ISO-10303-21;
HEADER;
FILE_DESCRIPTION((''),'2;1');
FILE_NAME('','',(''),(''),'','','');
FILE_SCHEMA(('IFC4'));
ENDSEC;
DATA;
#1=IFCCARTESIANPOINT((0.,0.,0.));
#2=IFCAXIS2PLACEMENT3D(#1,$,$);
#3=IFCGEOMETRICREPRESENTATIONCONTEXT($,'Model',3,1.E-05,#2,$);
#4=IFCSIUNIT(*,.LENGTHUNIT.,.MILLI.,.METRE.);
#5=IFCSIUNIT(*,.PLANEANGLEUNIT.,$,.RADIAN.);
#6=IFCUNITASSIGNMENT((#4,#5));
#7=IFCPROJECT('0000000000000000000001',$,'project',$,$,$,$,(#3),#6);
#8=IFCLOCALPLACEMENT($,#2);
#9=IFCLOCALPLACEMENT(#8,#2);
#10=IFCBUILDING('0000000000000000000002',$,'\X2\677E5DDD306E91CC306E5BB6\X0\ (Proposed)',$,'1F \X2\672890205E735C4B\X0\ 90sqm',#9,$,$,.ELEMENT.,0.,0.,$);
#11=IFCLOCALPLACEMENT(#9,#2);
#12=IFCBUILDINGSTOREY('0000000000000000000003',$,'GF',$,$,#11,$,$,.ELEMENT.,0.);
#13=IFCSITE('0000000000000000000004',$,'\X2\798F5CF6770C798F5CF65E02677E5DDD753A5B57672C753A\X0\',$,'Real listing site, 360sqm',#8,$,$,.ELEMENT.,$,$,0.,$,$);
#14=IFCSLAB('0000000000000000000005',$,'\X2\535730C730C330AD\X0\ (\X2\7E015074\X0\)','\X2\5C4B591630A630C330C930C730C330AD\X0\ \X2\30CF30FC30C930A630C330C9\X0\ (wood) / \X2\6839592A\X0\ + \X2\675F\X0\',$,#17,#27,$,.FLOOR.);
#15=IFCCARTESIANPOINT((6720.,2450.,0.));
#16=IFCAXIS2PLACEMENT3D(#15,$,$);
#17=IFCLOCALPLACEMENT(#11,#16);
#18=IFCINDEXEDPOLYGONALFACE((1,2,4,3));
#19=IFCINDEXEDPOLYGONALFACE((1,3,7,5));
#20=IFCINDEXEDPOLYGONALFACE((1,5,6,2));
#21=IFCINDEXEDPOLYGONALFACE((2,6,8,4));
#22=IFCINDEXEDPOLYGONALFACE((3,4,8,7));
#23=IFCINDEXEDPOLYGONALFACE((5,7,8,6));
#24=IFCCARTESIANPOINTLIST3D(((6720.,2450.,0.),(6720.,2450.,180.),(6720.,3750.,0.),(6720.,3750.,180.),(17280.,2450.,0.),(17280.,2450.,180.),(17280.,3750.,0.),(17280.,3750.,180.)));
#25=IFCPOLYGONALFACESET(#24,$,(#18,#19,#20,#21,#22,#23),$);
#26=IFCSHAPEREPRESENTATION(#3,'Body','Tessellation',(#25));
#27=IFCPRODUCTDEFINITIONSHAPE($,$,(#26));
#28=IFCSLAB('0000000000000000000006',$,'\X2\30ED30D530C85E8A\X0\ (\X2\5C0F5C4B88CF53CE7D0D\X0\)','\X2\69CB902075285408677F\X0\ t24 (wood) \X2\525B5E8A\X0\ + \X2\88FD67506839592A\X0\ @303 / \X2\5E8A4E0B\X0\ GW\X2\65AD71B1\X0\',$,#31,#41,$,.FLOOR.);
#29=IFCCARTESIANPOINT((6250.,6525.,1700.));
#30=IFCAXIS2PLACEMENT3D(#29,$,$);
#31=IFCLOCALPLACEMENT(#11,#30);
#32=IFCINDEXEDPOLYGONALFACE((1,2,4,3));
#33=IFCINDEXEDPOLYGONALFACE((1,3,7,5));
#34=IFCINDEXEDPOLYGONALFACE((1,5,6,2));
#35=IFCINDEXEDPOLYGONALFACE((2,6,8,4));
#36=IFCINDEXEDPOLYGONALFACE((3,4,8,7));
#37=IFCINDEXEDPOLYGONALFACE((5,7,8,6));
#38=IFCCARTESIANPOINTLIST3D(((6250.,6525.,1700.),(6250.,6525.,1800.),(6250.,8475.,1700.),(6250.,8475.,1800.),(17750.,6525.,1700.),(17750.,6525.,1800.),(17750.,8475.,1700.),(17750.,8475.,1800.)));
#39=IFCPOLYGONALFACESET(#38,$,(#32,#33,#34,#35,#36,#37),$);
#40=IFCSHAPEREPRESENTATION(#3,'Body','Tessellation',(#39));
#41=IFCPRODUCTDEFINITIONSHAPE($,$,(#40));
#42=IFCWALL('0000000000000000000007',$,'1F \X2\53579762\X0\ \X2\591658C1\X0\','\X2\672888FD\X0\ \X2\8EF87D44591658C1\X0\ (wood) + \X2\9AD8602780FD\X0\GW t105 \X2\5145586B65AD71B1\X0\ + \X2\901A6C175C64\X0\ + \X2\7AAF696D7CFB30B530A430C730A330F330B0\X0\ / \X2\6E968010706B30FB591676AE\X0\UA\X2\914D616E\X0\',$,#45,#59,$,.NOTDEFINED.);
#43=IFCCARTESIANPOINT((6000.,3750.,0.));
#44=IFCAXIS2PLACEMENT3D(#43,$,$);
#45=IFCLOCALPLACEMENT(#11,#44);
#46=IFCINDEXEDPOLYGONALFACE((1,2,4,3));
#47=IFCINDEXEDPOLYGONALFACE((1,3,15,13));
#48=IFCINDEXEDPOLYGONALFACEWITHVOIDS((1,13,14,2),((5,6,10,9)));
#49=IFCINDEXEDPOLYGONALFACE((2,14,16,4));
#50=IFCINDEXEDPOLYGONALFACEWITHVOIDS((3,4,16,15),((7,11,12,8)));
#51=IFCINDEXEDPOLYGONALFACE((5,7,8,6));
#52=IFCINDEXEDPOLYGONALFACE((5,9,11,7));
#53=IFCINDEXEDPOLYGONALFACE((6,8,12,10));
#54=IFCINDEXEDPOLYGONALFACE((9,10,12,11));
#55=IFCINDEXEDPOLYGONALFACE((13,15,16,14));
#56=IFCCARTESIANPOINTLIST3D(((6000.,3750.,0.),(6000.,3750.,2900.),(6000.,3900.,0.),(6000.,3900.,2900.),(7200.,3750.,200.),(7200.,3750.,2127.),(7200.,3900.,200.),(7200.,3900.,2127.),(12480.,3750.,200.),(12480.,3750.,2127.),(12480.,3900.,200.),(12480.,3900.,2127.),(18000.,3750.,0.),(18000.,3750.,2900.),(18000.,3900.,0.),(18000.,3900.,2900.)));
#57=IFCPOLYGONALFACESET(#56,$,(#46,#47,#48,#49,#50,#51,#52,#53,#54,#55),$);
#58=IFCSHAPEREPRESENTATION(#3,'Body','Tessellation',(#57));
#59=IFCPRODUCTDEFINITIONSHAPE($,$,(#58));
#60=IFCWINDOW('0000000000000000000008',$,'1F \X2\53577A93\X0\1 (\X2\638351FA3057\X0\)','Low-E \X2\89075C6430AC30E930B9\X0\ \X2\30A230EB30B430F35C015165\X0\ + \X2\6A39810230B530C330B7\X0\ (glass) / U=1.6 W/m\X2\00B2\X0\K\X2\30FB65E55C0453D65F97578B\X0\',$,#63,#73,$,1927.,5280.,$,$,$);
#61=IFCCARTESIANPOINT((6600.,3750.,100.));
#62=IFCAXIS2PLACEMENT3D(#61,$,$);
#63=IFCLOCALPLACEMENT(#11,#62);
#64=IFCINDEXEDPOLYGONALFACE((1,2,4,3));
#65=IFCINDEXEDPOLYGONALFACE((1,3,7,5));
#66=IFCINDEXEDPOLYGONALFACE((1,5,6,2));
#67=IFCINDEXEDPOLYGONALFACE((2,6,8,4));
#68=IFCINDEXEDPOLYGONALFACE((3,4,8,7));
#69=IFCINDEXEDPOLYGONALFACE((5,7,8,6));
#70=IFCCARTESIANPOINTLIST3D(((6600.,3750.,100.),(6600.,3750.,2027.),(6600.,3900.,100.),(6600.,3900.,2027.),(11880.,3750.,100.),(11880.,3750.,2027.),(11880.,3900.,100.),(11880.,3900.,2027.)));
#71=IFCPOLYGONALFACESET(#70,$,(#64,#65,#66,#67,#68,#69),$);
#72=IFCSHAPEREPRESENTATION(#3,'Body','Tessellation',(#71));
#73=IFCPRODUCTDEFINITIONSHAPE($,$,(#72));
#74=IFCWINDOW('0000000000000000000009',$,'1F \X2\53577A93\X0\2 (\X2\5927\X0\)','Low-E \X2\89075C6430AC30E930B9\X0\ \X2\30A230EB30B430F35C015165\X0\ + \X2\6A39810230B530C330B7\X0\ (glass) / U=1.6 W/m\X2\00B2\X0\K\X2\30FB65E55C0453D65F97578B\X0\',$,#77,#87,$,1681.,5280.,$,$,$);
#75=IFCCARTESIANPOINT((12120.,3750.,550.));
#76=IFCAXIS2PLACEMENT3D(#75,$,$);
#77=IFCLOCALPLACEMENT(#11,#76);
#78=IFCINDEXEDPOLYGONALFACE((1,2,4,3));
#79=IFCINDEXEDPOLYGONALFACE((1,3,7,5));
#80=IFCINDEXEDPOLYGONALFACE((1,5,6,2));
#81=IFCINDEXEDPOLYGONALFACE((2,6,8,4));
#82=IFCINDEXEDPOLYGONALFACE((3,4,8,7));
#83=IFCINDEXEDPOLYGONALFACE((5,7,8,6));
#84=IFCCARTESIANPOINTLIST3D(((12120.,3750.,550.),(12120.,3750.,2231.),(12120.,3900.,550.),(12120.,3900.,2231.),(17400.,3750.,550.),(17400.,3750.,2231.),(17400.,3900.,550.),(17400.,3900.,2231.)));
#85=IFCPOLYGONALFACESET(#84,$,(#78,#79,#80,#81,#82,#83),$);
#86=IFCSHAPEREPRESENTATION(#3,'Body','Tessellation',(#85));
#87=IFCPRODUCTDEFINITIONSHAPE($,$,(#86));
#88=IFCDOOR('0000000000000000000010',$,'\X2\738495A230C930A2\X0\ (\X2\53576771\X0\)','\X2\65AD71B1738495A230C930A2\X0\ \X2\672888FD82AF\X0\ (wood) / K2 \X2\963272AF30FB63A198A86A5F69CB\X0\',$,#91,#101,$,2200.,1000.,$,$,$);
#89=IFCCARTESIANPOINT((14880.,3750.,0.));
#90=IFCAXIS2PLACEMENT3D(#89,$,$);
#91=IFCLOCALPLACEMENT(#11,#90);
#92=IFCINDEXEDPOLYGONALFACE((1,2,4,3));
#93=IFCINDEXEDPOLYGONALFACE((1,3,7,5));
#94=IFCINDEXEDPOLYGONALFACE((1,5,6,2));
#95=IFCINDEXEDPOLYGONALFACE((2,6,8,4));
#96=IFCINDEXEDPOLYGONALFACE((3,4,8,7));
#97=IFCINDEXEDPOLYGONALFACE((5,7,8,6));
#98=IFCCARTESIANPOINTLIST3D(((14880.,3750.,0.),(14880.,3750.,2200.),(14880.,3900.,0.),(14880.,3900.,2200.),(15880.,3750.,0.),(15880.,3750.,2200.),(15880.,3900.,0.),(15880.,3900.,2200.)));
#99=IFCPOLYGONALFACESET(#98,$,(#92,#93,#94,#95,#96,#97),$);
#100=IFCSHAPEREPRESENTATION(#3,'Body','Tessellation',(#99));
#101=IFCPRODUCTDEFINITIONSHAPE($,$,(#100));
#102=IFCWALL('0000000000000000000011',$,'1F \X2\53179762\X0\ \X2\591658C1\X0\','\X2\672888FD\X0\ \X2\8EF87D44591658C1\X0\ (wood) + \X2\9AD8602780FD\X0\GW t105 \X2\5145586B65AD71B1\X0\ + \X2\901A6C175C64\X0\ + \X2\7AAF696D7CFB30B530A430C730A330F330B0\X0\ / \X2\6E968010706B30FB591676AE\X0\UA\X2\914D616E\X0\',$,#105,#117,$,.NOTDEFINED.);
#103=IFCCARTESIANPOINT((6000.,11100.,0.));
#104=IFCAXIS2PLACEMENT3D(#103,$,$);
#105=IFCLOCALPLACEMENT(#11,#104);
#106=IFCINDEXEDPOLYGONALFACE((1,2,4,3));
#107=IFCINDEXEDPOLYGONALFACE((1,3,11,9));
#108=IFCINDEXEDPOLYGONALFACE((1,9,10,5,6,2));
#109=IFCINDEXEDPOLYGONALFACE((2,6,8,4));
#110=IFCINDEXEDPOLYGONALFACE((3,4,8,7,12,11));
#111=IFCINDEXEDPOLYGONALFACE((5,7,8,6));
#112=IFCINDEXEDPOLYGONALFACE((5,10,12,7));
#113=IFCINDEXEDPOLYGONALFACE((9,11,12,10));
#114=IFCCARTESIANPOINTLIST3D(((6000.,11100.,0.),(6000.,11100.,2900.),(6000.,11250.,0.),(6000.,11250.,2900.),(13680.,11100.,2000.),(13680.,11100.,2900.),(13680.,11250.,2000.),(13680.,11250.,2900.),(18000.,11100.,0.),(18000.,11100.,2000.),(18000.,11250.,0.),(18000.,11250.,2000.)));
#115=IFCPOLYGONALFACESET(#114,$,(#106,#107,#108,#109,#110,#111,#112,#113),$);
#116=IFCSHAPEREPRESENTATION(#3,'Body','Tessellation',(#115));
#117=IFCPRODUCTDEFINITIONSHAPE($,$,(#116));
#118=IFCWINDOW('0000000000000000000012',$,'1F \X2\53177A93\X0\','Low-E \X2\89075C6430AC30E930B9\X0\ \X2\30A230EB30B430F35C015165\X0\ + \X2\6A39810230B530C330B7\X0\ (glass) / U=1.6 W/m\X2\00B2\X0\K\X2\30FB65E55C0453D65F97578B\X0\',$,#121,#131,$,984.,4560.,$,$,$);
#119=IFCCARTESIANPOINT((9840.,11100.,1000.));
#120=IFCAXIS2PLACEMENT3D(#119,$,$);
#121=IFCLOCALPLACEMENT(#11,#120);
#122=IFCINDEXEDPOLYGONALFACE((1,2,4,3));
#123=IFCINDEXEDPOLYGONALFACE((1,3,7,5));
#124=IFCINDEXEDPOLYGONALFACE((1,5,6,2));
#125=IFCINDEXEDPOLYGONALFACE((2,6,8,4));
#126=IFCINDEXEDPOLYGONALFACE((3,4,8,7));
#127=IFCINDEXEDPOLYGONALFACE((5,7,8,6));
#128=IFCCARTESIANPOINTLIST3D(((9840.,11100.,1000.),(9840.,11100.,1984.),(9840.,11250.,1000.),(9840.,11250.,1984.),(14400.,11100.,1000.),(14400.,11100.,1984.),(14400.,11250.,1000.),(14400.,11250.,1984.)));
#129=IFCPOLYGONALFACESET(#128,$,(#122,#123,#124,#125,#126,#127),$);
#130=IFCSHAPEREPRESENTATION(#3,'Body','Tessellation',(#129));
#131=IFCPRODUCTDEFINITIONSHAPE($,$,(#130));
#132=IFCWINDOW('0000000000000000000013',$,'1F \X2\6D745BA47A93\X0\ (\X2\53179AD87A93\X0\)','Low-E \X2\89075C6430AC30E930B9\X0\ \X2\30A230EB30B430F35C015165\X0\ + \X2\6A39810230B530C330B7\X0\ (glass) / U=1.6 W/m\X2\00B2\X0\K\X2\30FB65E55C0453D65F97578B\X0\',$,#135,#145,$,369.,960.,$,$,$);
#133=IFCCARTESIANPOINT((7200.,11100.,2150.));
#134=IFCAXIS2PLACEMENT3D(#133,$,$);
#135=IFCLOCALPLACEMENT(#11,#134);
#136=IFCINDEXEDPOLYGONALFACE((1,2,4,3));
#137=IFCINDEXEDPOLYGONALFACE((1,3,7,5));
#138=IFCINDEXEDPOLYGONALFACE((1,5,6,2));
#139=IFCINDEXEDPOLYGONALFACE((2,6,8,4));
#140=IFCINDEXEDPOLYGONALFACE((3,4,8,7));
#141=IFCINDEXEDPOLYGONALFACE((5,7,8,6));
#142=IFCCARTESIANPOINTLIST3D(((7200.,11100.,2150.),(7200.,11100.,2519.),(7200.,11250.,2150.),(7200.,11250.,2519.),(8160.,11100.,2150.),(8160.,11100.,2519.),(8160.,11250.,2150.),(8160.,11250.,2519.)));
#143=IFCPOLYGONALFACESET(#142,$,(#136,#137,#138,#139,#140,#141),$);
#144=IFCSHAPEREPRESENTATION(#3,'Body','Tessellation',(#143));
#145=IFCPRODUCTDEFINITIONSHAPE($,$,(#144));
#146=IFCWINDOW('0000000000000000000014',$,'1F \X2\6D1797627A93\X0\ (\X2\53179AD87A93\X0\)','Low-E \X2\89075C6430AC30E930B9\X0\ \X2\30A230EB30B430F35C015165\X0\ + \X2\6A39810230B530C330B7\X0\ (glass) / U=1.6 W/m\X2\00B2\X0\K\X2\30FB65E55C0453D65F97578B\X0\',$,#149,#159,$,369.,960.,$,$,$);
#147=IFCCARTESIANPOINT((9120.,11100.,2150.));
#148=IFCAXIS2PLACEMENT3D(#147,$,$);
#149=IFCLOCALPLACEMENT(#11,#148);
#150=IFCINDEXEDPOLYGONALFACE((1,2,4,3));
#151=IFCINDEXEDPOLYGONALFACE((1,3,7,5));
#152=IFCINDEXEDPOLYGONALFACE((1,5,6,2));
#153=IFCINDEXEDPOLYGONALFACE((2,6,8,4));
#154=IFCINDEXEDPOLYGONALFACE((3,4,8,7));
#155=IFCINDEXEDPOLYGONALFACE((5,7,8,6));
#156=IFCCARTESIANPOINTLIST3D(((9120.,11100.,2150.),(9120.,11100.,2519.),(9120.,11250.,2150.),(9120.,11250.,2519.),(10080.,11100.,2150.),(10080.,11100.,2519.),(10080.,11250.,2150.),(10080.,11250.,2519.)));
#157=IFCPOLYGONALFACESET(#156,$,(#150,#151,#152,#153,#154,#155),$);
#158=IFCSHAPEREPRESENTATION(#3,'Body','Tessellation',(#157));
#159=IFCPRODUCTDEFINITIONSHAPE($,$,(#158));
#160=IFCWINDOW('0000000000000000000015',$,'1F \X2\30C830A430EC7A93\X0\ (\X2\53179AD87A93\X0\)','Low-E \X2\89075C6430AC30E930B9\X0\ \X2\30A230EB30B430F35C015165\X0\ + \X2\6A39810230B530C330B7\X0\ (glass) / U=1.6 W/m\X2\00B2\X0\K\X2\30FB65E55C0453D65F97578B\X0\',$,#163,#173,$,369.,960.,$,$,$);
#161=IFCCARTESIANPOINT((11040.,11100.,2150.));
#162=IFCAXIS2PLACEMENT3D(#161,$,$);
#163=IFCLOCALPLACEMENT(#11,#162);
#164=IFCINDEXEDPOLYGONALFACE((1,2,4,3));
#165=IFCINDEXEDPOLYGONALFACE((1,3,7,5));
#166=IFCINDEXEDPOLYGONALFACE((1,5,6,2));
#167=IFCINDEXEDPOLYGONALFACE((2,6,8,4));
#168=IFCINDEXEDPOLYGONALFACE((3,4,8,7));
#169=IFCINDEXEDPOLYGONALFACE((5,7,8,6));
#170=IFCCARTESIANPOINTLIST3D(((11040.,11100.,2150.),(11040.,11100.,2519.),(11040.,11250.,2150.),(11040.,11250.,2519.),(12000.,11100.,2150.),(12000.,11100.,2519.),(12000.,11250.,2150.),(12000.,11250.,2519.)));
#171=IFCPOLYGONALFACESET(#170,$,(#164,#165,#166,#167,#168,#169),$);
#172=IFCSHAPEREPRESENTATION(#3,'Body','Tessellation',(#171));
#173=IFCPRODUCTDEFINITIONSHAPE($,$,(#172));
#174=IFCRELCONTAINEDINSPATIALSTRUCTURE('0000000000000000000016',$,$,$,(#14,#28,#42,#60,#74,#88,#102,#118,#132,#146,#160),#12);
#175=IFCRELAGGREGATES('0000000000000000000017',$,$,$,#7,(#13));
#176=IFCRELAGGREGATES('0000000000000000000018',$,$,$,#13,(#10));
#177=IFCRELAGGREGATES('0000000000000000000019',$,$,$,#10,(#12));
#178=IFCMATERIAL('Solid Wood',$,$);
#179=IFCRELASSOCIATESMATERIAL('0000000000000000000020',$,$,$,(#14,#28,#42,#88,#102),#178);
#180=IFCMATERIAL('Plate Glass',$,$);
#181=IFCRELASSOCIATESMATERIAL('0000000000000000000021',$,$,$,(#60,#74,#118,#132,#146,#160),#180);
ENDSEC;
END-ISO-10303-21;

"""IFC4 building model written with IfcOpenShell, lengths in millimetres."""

from ifc_helpers import new_model, si_unit, frame, frame_2d, origin, place, context, project, spatial, rectangle, extrude, material, element, fill, save


model = new_model("IFC4")

# Units and contexts
model_context = context("Model", 3, precision=1e-05, world=origin())
ifc_project = project(units=[si_unit("LENGTHUNIT", "METRE", prefix="MILLI"), si_unit("PLANEANGLEUNIT", "RADIAN")], contexts=[model_context])

# Site, building, storey
site_placement = place(None, origin())
site = spatial("IfcSite", under=ifc_project, at=site_placement, Name="福島県福島市松川町字本町", ObjectType="Real listing site, 360sqm", CompositionType="ELEMENT", RefElevation=0.0)
building_placement = place(site_placement, origin())
building = spatial("IfcBuilding", under=site, at=building_placement, Name="松川の里の家 (Proposed)", ObjectType="1F 木造平屋 90sqm", CompositionType="ELEMENT", ElevationOfRefHeight=0.0, ElevationOfTerrain=0.0)
storey_placement = place(building_placement, origin())
storey = spatial("IfcBuildingStorey", under=building, at=storey_placement, Name="GF", CompositionType="ELEMENT", Elevation=0.0)

# Slabs
ifc_material_1 = material(Name="Solid Wood")
slab_1_placement = place(storey_placement, frame((6720.0, 2450.0, 0.0)))
element("IfcSlab", 1, at=slab_1_placement, inside=storey, material=ifc_material_1, Name="南デッキ (縁側)", Description="屋外ウッドデッキ ハードウッド (wood) / 根太 + 束", PredefinedType="FLOOR", context=model_context, shape_type="SweptSolid", body=[
    extrude(rectangle(XDim=10560.0, YDim=1300.0, at=frame_2d((5280.0, 650.0))), frame((6720.0, 2450.0, 0.0)), (0.0, 0.0, 1.0), 180.0),
])
slab_2_placement = place(storey_placement, frame((6250.0, 6525.0, 1700.0)))
element("IfcSlab", 2, at=slab_2_placement, inside=storey, material=ifc_material_1, Name="ロフト床 (小屋裏収納)", Description="構造用合板 t24 (wood) 剛床 + 製材根太 @303 / 床下 GW断熱", PredefinedType="FLOOR", context=model_context, shape_type="SweptSolid", body=[
    extrude(rectangle(XDim=11500.0, YDim=1950.0, at=frame_2d((5750.0, 975.0))), frame((6250.0, 6525.0, 1700.0)), (0.0, 0.0, 1.0), 100.0),
])

# Wall, openings, windows, door
wall_1_placement = place(storey_placement, frame((6000.0, 3750.0, 0.0)))
wall_1 = element("IfcWall", 3, at=wall_1_placement, inside=storey, material=ifc_material_1, Name="1F 南面 外壁", Description="木製 軸組外壁 (wood) + 高性能GW t105 充填断熱 + 通気層 + 窯業系サイディング / 準耐火・外皮UA配慮", PredefinedType="NOTDEFINED", context=model_context, shape_type="SweptSolid", body=[
    extrude(rectangle(XDim=12000.0, YDim=150.0, at=frame_2d((6000.0, 75.0))), frame((6000.0, 3750.0, 0.0)), (0.0, 0.0, 1.0), 2900.0),
])
opening_1_placement = place(storey_placement, frame((6600.0, 3750.0, 100.0)))
opening_1 = element("IfcOpeningElement", 4, at=opening_1_placement, cuts=wall_1, PredefinedType="NOTDEFINED", context=model_context, shape_type="SweptSolid", body=[
    extrude(rectangle(XDim=5280.0, YDim=150.0, at=frame_2d((2640.0, 75.0))), frame((6600.0, 3750.0, 100.0)), (0.0, 0.0, 1.0), 1927.0),
])
opening_2_placement = place(storey_placement, frame((12120.0, 3750.0, 550.0)))
opening_2 = element("IfcOpeningElement", 5, at=opening_2_placement, cuts=wall_1, PredefinedType="NOTDEFINED", context=model_context, shape_type="SweptSolid", body=[
    extrude(rectangle(XDim=5280.0, YDim=150.0, at=frame_2d((2640.0, 75.0))), frame((12120.0, 3750.0, 550.0)), (0.0, 0.0, 1.0), 1681.0),
])
opening_3_placement = place(storey_placement, frame((14880.0, 3750.0, 0.0)))
opening_3 = element("IfcOpeningElement", 6, at=opening_3_placement, cuts=wall_1, PredefinedType="NOTDEFINED", context=model_context, shape_type="SweptSolid", body=[
    extrude(rectangle(XDim=1000.0, YDim=150.0, at=frame_2d((500.0, 75.0))), frame((14880.0, 3750.0, 0.0)), (0.0, 0.0, 1.0), 2200.0),
])
ifc_material_2 = material(Name="Plate Glass")
window_1_placement = place(storey_placement, frame((6600.0, 3750.0, 100.0)))
window_1 = element("IfcWindow", 7, at=window_1_placement, inside=storey, material=ifc_material_2, Name="1F 南窓1 (掃出し)", Description="Low-E 複層ガラス アルゴン封入 + 樹脂サッシ (glass) / U=1.6 W/m²K・日射取得型", OverallHeight=1927.0, OverallWidth=5280.0, context=model_context, shape_type="SweptSolid", body=[
    extrude(rectangle(XDim=5280.0, YDim=150.0, at=frame_2d((2640.0, 75.0))), frame((6600.0, 3750.0, 100.0)), (0.0, 0.0, 1.0), 1927.0),
])
fill(opening_1, window_1)
window_2_placement = place(storey_placement, frame((12120.0, 3750.0, 550.0)))
window_2 = element("IfcWindow", 8, at=window_2_placement, inside=storey, material=ifc_material_2, Name="1F 南窓2 (大)", Description="Low-E 複層ガラス アルゴン封入 + 樹脂サッシ (glass) / U=1.6 W/m²K・日射取得型", OverallHeight=1681.0, OverallWidth=5280.0, context=model_context, shape_type="SweptSolid", body=[
    extrude(rectangle(XDim=5280.0, YDim=150.0, at=frame_2d((2640.0, 75.0))), frame((12120.0, 3750.0, 550.0)), (0.0, 0.0, 1.0), 1681.0),
])
fill(opening_2, window_2)
door_1_placement = place(storey_placement, frame((14880.0, 3750.0, 0.0)))
door_1 = element("IfcDoor", 9, at=door_1_placement, inside=storey, material=ifc_material_1, Name="玄関ドア (南東)", Description="断熱玄関ドア 木製芯 (wood) / K2 防犯・採風機構", OverallHeight=2200.0, OverallWidth=1000.0, context=model_context, shape_type="SweptSolid", body=[
    extrude(rectangle(XDim=1000.0, YDim=150.0, at=frame_2d((500.0, 75.0))), frame((14880.0, 3750.0, 0.0)), (0.0, 0.0, 1.0), 2200.0),
])
fill(opening_3, door_1)

# Wall, openings, windows
wall_2_placement = place(storey_placement, frame((6000.0, 11100.0, 0.0)))
wall_2 = element("IfcWall", 10, at=wall_2_placement, inside=storey, material=ifc_material_1, Name="1F 北面 外壁", Description="木製 軸組外壁 (wood) + 高性能GW t105 充填断熱 + 通気層 + 窯業系サイディング / 準耐火・外皮UA配慮", PredefinedType="NOTDEFINED", context=model_context, shape_type="SweptSolid", body=[
    extrude(rectangle(XDim=12000.0, YDim=150.0, at=frame_2d((6000.0, 75.0))), frame((6000.0, 11100.0, 0.0)), (0.0, 0.0, 1.0), 2900.0),
])
opening_4_placement = place(storey_placement, frame((9840.0, 11100.0, 1000.0)))
opening_4 = element("IfcOpeningElement", 11, at=opening_4_placement, cuts=wall_2, PredefinedType="NOTDEFINED", context=model_context, shape_type="SweptSolid", body=[
    extrude(rectangle(XDim=4560.0, YDim=150.0, at=frame_2d((2280.0, 75.0))), frame((9840.0, 11100.0, 1000.0)), (0.0, 0.0, 1.0), 984.0),
])
opening_5_placement = place(storey_placement, frame((7200.0, 11100.0, 2150.0)))
opening_5 = element("IfcOpeningElement", 12, at=opening_5_placement, cuts=wall_2, PredefinedType="NOTDEFINED", context=model_context, shape_type="SweptSolid", body=[
    extrude(rectangle(XDim=960.0, YDim=150.0, at=frame_2d((480.0, 75.0))), frame((7200.0, 11100.0, 2150.0)), (0.0, 0.0, 1.0), 369.0),
])
opening_6_placement = place(storey_placement, frame((9120.0, 11100.0, 2150.0)))
opening_6 = element("IfcOpeningElement", 13, at=opening_6_placement, cuts=wall_2, PredefinedType="NOTDEFINED", context=model_context, shape_type="SweptSolid", body=[
    extrude(rectangle(XDim=960.0, YDim=150.0, at=frame_2d((480.0, 75.0))), frame((9120.0, 11100.0, 2150.0)), (0.0, 0.0, 1.0), 369.0),
])
opening_7_placement = place(storey_placement, frame((11040.0, 11100.0, 2150.0)))
opening_7 = element("IfcOpeningElement", 14, at=opening_7_placement, cuts=wall_2, PredefinedType="NOTDEFINED", context=model_context, shape_type="SweptSolid", body=[
    extrude(rectangle(XDim=960.0, YDim=150.0, at=frame_2d((480.0, 75.0))), frame((11040.0, 11100.0, 2150.0)), (0.0, 0.0, 1.0), 369.0),
])
window_3_placement = place(storey_placement, frame((9840.0, 11100.0, 1000.0)))
window_3 = element("IfcWindow", 15, at=window_3_placement, inside=storey, material=ifc_material_2, Name="1F 北窓", Description="Low-E 複層ガラス アルゴン封入 + 樹脂サッシ (glass) / U=1.6 W/m²K・日射取得型", OverallHeight=984.0, OverallWidth=4560.0, context=model_context, shape_type="SweptSolid", body=[
    extrude(rectangle(XDim=4560.0, YDim=150.0, at=frame_2d((2280.0, 75.0))), frame((9840.0, 11100.0, 1000.0)), (0.0, 0.0, 1.0), 984.0),
])
fill(opening_4, window_3)
window_4_placement = place(storey_placement, frame((7200.0, 11100.0, 2150.0)))
window_4 = element("IfcWindow", 16, at=window_4_placement, inside=storey, material=ifc_material_2, Name="1F 浴室窓 (北高窓)", Description="Low-E 複層ガラス アルゴン封入 + 樹脂サッシ (glass) / U=1.6 W/m²K・日射取得型", OverallHeight=369.0, OverallWidth=960.0, context=model_context, shape_type="SweptSolid", body=[
    extrude(rectangle(XDim=960.0, YDim=150.0, at=frame_2d((480.0, 75.0))), frame((7200.0, 11100.0, 2150.0)), (0.0, 0.0, 1.0), 369.0),
])
fill(opening_5, window_4)
window_5_placement = place(storey_placement, frame((9120.0, 11100.0, 2150.0)))
window_5 = element("IfcWindow", 17, at=window_5_placement, inside=storey, material=ifc_material_2, Name="1F 洗面窓 (北高窓)", Description="Low-E 複層ガラス アルゴン封入 + 樹脂サッシ (glass) / U=1.6 W/m²K・日射取得型", OverallHeight=369.0, OverallWidth=960.0, context=model_context, shape_type="SweptSolid", body=[
    extrude(rectangle(XDim=960.0, YDim=150.0, at=frame_2d((480.0, 75.0))), frame((9120.0, 11100.0, 2150.0)), (0.0, 0.0, 1.0), 369.0),
])
fill(opening_6, window_5)
window_6_placement = place(storey_placement, frame((11040.0, 11100.0, 2150.0)))
window_6 = element("IfcWindow", 18, at=window_6_placement, inside=storey, material=ifc_material_2, Name="1F トイレ窓 (北高窓)", Description="Low-E 複層ガラス アルゴン封入 + 樹脂サッシ (glass) / U=1.6 W/m²K・日射取得型", OverallHeight=369.0, OverallWidth=960.0, context=model_context, shape_type="SweptSolid", body=[
    extrude(rectangle(XDim=960.0, YDim=150.0, at=frame_2d((480.0, 75.0))), frame((11040.0, 11100.0, 2150.0)), (0.0, 0.0, 1.0), 369.0),
])
fill(opening_7, window_6)

save(model, "model.ifc")
